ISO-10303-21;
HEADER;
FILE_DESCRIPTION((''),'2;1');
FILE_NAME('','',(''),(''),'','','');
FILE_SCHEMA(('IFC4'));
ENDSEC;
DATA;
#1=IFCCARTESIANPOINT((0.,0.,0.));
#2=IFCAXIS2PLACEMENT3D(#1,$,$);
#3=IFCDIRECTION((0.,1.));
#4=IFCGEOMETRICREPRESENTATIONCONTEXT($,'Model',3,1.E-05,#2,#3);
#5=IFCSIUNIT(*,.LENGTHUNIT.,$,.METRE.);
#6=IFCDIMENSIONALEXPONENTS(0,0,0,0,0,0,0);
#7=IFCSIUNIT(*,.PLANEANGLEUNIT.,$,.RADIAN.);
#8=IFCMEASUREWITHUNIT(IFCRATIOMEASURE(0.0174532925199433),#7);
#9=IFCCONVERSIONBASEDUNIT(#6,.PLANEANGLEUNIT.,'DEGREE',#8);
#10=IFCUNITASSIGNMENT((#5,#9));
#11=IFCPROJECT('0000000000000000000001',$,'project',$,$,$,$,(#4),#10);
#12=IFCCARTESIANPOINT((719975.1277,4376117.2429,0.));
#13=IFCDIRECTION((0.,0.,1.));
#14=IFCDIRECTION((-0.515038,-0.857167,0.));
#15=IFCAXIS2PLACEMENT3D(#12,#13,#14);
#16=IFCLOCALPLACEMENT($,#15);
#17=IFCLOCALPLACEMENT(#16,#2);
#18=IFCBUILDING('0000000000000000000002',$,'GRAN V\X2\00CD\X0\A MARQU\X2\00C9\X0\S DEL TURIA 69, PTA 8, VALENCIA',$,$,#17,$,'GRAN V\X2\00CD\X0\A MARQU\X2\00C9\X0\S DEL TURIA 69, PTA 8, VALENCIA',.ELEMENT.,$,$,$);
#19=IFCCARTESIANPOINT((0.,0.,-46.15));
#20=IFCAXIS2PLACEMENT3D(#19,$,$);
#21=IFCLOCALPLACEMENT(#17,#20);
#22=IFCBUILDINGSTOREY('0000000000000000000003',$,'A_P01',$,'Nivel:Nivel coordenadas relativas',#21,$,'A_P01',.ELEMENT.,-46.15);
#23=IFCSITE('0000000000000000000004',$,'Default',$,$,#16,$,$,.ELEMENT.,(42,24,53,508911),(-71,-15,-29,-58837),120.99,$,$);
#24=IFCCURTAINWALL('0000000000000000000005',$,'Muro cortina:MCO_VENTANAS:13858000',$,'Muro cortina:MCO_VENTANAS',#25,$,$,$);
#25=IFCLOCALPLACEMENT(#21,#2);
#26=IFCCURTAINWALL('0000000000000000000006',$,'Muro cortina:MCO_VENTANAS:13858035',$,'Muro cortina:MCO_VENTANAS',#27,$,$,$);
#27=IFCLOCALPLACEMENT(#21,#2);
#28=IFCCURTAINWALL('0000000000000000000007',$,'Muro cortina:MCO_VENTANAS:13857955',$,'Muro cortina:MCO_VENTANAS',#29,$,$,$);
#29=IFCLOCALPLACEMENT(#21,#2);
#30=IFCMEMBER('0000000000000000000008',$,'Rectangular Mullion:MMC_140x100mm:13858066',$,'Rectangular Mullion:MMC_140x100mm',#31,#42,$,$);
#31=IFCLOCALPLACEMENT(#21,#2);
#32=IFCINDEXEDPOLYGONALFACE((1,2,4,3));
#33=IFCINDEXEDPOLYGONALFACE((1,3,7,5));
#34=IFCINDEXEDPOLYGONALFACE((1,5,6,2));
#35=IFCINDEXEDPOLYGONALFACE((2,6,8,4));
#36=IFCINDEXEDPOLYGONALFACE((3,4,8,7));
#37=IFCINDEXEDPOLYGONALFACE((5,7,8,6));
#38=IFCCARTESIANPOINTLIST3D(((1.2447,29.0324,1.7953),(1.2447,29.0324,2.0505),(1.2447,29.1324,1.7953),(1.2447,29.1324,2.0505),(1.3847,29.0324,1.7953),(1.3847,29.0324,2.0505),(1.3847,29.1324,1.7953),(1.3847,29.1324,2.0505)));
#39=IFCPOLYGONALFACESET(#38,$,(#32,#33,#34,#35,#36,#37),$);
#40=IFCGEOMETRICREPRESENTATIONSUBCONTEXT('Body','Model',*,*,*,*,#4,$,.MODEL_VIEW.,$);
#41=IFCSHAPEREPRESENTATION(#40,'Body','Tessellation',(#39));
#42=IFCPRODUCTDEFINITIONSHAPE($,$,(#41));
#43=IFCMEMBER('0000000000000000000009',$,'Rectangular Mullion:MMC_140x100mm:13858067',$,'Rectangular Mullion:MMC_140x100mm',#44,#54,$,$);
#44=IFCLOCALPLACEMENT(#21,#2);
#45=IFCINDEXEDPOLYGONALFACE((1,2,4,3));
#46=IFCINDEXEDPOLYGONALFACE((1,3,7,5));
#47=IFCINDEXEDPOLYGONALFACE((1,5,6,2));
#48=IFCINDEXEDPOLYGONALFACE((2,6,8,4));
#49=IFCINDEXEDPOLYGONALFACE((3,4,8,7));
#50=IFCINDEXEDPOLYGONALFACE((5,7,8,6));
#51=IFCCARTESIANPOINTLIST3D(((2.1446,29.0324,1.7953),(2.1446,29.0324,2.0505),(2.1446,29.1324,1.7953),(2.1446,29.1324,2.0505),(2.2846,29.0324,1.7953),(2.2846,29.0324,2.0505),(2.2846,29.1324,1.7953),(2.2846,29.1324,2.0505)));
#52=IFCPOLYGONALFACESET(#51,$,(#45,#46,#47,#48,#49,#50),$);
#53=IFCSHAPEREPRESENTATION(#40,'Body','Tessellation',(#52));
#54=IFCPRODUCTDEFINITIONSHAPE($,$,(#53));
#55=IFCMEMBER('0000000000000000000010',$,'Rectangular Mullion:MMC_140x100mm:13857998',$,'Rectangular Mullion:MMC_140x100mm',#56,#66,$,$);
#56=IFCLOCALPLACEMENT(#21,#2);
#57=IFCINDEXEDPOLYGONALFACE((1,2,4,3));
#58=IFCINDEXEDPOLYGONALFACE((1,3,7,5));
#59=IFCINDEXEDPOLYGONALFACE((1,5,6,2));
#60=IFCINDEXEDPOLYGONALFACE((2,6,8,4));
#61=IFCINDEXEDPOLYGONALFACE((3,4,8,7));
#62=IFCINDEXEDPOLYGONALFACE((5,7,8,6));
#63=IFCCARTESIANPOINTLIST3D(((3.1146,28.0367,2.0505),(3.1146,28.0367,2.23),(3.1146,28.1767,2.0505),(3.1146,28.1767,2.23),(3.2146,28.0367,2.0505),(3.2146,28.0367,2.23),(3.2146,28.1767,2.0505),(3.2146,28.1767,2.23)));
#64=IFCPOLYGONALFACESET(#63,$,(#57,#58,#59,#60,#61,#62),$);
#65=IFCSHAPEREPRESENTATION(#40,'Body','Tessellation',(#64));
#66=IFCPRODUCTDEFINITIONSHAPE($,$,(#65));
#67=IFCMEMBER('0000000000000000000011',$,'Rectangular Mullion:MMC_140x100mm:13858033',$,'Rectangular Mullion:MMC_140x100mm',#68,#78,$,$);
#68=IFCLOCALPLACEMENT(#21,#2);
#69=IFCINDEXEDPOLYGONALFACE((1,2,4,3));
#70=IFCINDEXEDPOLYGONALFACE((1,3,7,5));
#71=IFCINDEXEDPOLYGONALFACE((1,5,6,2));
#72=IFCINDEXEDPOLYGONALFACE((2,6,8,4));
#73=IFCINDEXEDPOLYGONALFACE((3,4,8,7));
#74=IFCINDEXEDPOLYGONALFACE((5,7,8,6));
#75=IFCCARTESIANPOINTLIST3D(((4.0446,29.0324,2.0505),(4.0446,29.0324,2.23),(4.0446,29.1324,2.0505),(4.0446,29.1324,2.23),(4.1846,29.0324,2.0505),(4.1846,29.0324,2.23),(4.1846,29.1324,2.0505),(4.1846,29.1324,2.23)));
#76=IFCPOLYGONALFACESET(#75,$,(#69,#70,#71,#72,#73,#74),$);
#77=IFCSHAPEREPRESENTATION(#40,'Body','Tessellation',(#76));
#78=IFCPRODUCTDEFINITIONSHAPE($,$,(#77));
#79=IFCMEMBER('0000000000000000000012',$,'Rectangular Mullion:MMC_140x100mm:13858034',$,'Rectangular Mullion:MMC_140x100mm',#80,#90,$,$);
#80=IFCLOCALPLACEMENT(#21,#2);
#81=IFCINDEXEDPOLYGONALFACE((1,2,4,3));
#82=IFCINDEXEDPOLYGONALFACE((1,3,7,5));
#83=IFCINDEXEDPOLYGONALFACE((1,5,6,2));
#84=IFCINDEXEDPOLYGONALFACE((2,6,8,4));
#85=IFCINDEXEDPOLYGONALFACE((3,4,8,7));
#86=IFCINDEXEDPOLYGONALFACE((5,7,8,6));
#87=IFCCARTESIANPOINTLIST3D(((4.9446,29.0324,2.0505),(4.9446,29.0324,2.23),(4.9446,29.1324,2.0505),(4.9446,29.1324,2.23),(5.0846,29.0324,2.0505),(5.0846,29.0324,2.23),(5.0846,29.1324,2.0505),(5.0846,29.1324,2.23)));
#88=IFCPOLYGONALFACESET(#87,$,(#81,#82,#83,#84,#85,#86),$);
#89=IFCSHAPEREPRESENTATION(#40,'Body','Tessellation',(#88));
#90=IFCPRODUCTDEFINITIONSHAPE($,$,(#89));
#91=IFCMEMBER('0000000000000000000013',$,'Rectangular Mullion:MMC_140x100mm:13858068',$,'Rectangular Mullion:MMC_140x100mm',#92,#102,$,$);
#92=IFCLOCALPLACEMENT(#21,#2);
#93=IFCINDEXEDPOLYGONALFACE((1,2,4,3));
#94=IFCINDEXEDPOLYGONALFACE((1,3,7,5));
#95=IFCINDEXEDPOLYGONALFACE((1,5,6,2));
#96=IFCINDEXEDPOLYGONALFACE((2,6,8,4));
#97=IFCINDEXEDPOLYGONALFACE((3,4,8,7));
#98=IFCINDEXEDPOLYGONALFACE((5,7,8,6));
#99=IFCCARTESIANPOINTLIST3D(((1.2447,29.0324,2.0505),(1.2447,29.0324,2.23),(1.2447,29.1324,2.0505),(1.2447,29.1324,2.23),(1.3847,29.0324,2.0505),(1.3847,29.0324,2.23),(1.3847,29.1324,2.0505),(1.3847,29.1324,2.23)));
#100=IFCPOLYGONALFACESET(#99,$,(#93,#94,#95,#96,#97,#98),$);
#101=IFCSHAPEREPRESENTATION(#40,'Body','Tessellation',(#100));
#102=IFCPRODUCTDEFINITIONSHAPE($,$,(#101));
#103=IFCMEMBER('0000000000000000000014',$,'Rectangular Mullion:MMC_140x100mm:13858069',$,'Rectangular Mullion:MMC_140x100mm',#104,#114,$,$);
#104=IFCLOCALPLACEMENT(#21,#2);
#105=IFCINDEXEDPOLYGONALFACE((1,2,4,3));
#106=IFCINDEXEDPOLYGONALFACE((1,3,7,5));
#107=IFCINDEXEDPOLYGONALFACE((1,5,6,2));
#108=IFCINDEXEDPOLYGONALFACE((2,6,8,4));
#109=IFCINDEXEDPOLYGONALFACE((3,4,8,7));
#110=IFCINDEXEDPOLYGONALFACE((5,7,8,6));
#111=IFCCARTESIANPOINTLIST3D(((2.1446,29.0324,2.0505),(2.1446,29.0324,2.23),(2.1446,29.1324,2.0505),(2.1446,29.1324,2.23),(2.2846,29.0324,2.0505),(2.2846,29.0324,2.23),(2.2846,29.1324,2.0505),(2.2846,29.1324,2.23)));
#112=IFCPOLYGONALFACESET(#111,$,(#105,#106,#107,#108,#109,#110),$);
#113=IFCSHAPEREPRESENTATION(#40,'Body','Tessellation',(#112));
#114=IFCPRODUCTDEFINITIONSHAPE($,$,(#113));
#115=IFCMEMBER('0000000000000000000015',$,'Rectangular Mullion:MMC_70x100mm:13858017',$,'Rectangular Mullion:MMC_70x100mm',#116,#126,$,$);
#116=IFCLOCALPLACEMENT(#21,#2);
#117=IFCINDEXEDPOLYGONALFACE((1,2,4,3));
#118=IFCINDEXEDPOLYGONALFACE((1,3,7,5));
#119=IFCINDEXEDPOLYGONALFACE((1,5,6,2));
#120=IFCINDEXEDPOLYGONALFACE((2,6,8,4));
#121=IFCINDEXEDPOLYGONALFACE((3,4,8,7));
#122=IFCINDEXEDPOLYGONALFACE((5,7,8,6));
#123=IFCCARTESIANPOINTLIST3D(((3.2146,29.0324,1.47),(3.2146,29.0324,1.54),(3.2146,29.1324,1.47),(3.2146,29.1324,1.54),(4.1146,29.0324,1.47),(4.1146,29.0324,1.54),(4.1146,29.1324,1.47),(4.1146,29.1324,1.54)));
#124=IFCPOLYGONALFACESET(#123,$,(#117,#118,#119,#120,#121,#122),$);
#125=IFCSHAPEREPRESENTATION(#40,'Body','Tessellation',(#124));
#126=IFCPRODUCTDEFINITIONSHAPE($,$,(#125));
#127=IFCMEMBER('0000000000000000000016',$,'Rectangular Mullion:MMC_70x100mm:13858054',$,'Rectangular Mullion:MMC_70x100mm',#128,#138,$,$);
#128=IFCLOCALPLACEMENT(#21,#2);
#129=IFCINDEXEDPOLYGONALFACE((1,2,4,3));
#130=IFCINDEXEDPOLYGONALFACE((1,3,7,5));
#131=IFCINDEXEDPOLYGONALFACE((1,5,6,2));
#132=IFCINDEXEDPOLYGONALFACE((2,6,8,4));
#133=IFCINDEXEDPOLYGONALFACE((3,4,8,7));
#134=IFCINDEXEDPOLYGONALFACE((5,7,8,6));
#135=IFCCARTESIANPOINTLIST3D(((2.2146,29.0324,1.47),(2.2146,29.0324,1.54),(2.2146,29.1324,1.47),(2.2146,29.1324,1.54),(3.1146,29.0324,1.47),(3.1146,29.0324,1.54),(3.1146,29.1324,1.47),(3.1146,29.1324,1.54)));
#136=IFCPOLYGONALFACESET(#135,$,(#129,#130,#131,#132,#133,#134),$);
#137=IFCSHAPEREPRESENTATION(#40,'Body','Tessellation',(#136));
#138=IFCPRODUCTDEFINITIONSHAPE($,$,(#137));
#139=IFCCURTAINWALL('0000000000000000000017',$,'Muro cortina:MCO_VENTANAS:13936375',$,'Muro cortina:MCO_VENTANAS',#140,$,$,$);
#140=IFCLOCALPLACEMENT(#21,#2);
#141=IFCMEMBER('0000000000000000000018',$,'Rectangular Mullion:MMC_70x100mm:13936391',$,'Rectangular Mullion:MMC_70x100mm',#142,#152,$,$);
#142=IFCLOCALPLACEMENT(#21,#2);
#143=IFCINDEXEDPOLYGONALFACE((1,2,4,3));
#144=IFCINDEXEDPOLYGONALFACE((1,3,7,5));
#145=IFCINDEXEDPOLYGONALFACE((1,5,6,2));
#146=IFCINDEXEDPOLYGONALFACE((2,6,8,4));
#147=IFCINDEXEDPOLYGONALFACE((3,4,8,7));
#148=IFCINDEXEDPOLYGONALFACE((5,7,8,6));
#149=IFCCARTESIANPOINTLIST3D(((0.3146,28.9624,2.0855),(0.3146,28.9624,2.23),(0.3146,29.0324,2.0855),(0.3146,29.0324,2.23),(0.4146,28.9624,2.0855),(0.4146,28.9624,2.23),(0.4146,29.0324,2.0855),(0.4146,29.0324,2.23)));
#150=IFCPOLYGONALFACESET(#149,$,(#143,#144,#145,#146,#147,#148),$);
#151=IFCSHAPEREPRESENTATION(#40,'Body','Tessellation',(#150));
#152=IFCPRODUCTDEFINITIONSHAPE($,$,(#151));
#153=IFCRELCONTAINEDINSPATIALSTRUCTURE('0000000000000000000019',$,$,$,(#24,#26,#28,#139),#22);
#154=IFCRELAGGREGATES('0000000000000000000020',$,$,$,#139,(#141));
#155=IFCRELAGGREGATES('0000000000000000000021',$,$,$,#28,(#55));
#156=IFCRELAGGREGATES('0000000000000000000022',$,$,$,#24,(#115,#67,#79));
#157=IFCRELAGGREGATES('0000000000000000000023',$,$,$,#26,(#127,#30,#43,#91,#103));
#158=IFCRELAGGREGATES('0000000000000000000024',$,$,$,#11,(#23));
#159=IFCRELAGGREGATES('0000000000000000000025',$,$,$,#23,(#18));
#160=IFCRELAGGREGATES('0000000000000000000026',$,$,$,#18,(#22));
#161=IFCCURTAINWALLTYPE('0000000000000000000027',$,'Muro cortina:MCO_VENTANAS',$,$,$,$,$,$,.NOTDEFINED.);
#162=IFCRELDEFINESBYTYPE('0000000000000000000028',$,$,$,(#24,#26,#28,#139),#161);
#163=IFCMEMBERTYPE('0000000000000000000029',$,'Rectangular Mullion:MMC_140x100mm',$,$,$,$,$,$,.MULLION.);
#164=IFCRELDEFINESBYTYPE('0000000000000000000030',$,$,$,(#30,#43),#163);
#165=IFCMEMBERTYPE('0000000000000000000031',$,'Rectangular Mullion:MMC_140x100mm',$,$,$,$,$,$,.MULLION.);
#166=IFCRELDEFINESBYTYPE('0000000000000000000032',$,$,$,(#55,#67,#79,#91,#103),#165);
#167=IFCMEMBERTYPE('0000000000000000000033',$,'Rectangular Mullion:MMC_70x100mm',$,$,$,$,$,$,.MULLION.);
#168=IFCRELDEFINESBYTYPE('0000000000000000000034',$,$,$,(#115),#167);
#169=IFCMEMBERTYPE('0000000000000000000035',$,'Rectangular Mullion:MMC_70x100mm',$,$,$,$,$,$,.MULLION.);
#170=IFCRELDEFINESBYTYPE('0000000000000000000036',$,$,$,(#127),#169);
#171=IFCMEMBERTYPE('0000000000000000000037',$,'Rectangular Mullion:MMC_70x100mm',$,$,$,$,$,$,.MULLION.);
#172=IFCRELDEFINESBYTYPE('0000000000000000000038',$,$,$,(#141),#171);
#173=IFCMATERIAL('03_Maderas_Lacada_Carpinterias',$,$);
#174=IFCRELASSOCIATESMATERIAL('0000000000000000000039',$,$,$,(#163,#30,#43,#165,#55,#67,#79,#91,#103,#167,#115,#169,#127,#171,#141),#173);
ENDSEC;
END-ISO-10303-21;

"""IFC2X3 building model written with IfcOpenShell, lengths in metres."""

from ifc_helpers import new_model, entity, si_unit, converted_unit, direction, frame, origin, origin_2d_with_axis, place, context, subcontext, project, spatial, rectangle, extrude, source, transform, mapped, material, type_object, type_shapes, element, aggregate, save


model = new_model("IFC2X3")

# Units and contexts
model_context = context("Model", 3, precision=1e-05, world=origin(), true_north=direction((0.0, 1.0)))
body_context = subcontext(model_context, "Body", "Model", "MODEL_VIEW")
ifc_project = project(units=[si_unit("LENGTHUNIT", "METRE"), converted_unit("PLANEANGLEUNIT", "DEGREE", entity("IfcRatioMeasure", 0.0174532925199433), si_unit("PLANEANGLEUNIT", "RADIAN"), dimensions=[0, 0, 0, 0, 0, 0, 0])], contexts=[model_context])

# Site, building, storey
site_placement = place(None, frame((719975.1277, 4376117.2429, 0.0), z_axis=(0.0, 0.0, 1.0), x_axis=(-0.515038, -0.857167, 0.0)))
site = spatial("IfcSite", under=ifc_project, at=site_placement, Name="Default", CompositionType="ELEMENT", RefLatitude=(42, 24, 53, 508911), RefLongitude=(-71, -15, -29, -58837), RefElevation=120.99)
building_placement = place(site_placement, origin())
building = spatial("IfcBuilding", under=site, at=building_placement, Name="GRAN VÍA MARQUÉS DEL TURIA 69, PTA 8, VALENCIA", LongName="GRAN VÍA MARQUÉS DEL TURIA 69, PTA 8, VALENCIA", CompositionType="ELEMENT")
storey_placement = place(building_placement, frame((0.0, 0.0, -46.15)))
storey = spatial("IfcBuildingStorey", under=building, at=storey_placement, Name="A_P01", ObjectType="Nivel:Nivel coordenadas relativas", LongName="A_P01", CompositionType="ELEMENT", Elevation=-46.15)

# Curtain wall
curtain_wall_type = type_object("IfcCurtainWallType", Name="Muro cortina:MCO_VENTANAS", PredefinedType="NOTDEFINED")
curtain_wall_1_placement = place(storey_placement, frame((0.0, 0.0, 46.15)))
curtain_wall_1 = element("IfcCurtainWall", 1, at=curtain_wall_1_placement, inside=storey, type_object=curtain_wall_type, Name="Muro cortina:MCO_VENTANAS:13858000", ObjectType="Muro cortina:MCO_VENTANAS")
ifc_material_1 = material(Name="03_Maderas_Lacada_Carpinterias")

# Curtain wall
curtain_wall_2_placement = place(storey_placement, frame((0.0, 0.0, 46.15)))
curtain_wall_2 = element("IfcCurtainWall", 2, at=curtain_wall_2_placement, inside=storey, type_object=curtain_wall_type, Name="Muro cortina:MCO_VENTANAS:13858035", ObjectType="Muro cortina:MCO_VENTANAS")

# Curtain wall
curtain_wall_3_placement = place(storey_placement, frame((0.0, 0.0, 46.15)))
curtain_wall_3 = element("IfcCurtainWall", 3, at=curtain_wall_3_placement, inside=storey, type_object=curtain_wall_type, Name="Muro cortina:MCO_VENTANAS:13857955", ObjectType="Muro cortina:MCO_VENTANAS")

# Members
member_type_1 = type_object("IfcMemberType", Name="Rectangular Mullion:MMC_140x100mm", PredefinedType="MULLION", material=ifc_material_1)
shared_shape_1 = source(origin(), body_context, "Body", "SweptSolid", [
    extrude(rectangle(XDim=0.1, YDim=0.14, at=origin_2d_with_axis()), frame((0.0, 0.0, -0.2552), z_axis=(0.0, 0.0, 1.0), x_axis=(0.0, -1.0, 0.0)), (0.0, 0.0, 1.0), 0.2552),
])
type_shapes(member_type_1, [shared_shape_1])
member_1_placement = place(storey_placement, frame((1.3147, 29.0824, 1.7953), z_axis=(0.0, 0.0, -1.0), x_axis=(1.0, 0.0, 0.0)))
member_1 = element("IfcMember", 4, at=member_1_placement, type_object=member_type_1, material=ifc_material_1, Name="Rectangular Mullion:MMC_140x100mm:13858066", ObjectType="Rectangular Mullion:MMC_140x100mm", context=body_context, shape_type="MappedRepresentation", body=[
    mapped(shared_shape_1, transform((0.0, 0.0, 0.0), scale=1.0)),
])
member_2_placement = place(storey_placement, frame((2.2146, 29.0824, 1.7953), z_axis=(0.0, 0.0, -1.0), x_axis=(1.0, 0.0, 0.0)))
member_2 = element("IfcMember", 5, at=member_2_placement, type_object=member_type_1, material=ifc_material_1, Name="Rectangular Mullion:MMC_140x100mm:13858067", ObjectType="Rectangular Mullion:MMC_140x100mm", context=body_context, shape_type="MappedRepresentation", body=[
    mapped(shared_shape_1, transform((0.0, 0.0, 0.0), scale=1.0)),
])
member_type_2 = type_object("IfcMemberType", Name="Rectangular Mullion:MMC_140x100mm", PredefinedType="MULLION", material=ifc_material_1)
shared_shape_2 = source(origin(), body_context, "Body", "SweptSolid", [
    extrude(rectangle(XDim=0.1, YDim=0.14, at=origin_2d_with_axis()), frame((0.0, 0.0, -0.1795), z_axis=(0.0, 0.0, 1.0), x_axis=(0.0, -1.0, 0.0)), (0.0, 0.0, 1.0), 0.1795),
])
type_shapes(member_type_2, [shared_shape_2])
member_3_placement = place(storey_placement, frame((3.1646, 28.1067, 2.0505), z_axis=(0.0, 0.0, -1.0), x_axis=(0.0, 1.0, 0.0)))
member_3 = element("IfcMember", 6, at=member_3_placement, type_object=member_type_2, material=ifc_material_1, Name="Rectangular Mullion:MMC_140x100mm:13857998", ObjectType="Rectangular Mullion:MMC_140x100mm", context=body_context, shape_type="MappedRepresentation", body=[
    mapped(shared_shape_2, transform((0.0, 0.0, 0.0), scale=1.0)),
])
member_4_placement = place(storey_placement, frame((4.1146, 29.0824, 2.0505), z_axis=(0.0, 0.0, -1.0), x_axis=(1.0, 0.0, 0.0)))
member_4 = element("IfcMember", 7, at=member_4_placement, type_object=member_type_2, material=ifc_material_1, Name="Rectangular Mullion:MMC_140x100mm:13858033", ObjectType="Rectangular Mullion:MMC_140x100mm", context=body_context, shape_type="MappedRepresentation", body=[
    mapped(shared_shape_2, transform((0.0, 0.0, 0.0), scale=1.0)),
])
member_5_placement = place(storey_placement, frame((5.0146, 29.0824, 2.0505), z_axis=(0.0, 0.0, -1.0), x_axis=(1.0, 0.0, 0.0)))
member_5 = element("IfcMember", 8, at=member_5_placement, type_object=member_type_2, material=ifc_material_1, Name="Rectangular Mullion:MMC_140x100mm:13858034", ObjectType="Rectangular Mullion:MMC_140x100mm", context=body_context, shape_type="MappedRepresentation", body=[
    mapped(shared_shape_2, transform((0.0, 0.0, 0.0), scale=1.0)),
])
member_6_placement = place(storey_placement, frame((1.3147, 29.0824, 2.0505), z_axis=(0.0, 0.0, -1.0), x_axis=(1.0, 0.0, 0.0)))
member_6 = element("IfcMember", 9, at=member_6_placement, type_object=member_type_2, material=ifc_material_1, Name="Rectangular Mullion:MMC_140x100mm:13858068", ObjectType="Rectangular Mullion:MMC_140x100mm", context=body_context, shape_type="MappedRepresentation", body=[
    mapped(shared_shape_2, transform((0.0, 0.0, 0.0), scale=1.0)),
])
member_7_placement = place(storey_placement, frame((2.2146, 29.0824, 2.0505), z_axis=(0.0, 0.0, -1.0), x_axis=(1.0, 0.0, 0.0)))
member_7 = element("IfcMember", 10, at=member_7_placement, type_object=member_type_2, material=ifc_material_1, Name="Rectangular Mullion:MMC_140x100mm:13858069", ObjectType="Rectangular Mullion:MMC_140x100mm", context=body_context, shape_type="MappedRepresentation", body=[
    mapped(shared_shape_2, transform((0.0, 0.0, 0.0), scale=1.0)),
])
member_type_3 = type_object("IfcMemberType", Name="Rectangular Mullion:MMC_70x100mm", PredefinedType="MULLION", material=ifc_material_1)
shared_shape_3 = source(origin(), body_context, "Body", "SweptSolid", [
    extrude(rectangle(XDim=0.1, YDim=0.07, at=origin_2d_with_axis()), frame((-0.035, 0.0, -0.9), z_axis=(0.0, 0.0, 1.0), x_axis=(0.0, -1.0, 0.0)), (0.0, 0.0, 1.0), 0.9),
])
type_shapes(member_type_3, [shared_shape_3])
member_8_placement = place(storey_placement, frame((3.2146, 29.0824, 1.47), z_axis=(-1.0, 0.0, 0.0), x_axis=(0.0, 0.0, -1.0)))
member_8 = element("IfcMember", 11, at=member_8_placement, type_object=member_type_3, material=ifc_material_1, Name="Rectangular Mullion:MMC_70x100mm:13858017", ObjectType="Rectangular Mullion:MMC_70x100mm", context=body_context, shape_type="MappedRepresentation", body=[
    mapped(shared_shape_3, transform((0.0, 0.0, 0.0), scale=1.0)),
])
member_type_4 = type_object("IfcMemberType", Name="Rectangular Mullion:MMC_70x100mm", PredefinedType="MULLION", material=ifc_material_1)
shared_shape_4 = source(origin(), body_context, "Body", "SweptSolid", [
    extrude(rectangle(XDim=0.1, YDim=0.07, at=origin_2d_with_axis()), frame((-0.035, 0.0, -0.9), z_axis=(0.0, 0.0, 1.0), x_axis=(0.0, -1.0, 0.0)), (0.0, 0.0, 1.0), 0.9),
])
type_shapes(member_type_4, [shared_shape_4])
member_9_placement = place(storey_placement, frame((2.2146, 29.0824, 1.47), z_axis=(-1.0, 0.0, 0.0), x_axis=(0.0, 0.0, -1.0)))
member_9 = element("IfcMember", 12, at=member_9_placement, type_object=member_type_4, material=ifc_material_1, Name="Rectangular Mullion:MMC_70x100mm:13858054", ObjectType="Rectangular Mullion:MMC_70x100mm", context=body_context, shape_type="MappedRepresentation", body=[
    mapped(shared_shape_4, transform((0.0, 0.0, 0.0), scale=1.0)),
])

# Curtain wall, member
curtain_wall_4_placement = place(storey_placement, frame((0.0, 0.0, 46.15)))
curtain_wall_4 = element("IfcCurtainWall", 13, at=curtain_wall_4_placement, inside=storey, type_object=curtain_wall_type, Name="Muro cortina:MCO_VENTANAS:13936375", ObjectType="Muro cortina:MCO_VENTANAS")
member_type_5 = type_object("IfcMemberType", Name="Rectangular Mullion:MMC_70x100mm", PredefinedType="MULLION", material=ifc_material_1)
shared_shape_5 = source(origin(), body_context, "Body", "SweptSolid", [
    extrude(rectangle(XDim=0.1, YDim=0.07, at=origin_2d_with_axis()), frame((-0.035, 0.0, -0.1445), z_axis=(0.0, 0.0, 1.0), x_axis=(0.0, -1.0, 0.0)), (0.0, 0.0, 1.0), 0.1445),
])
type_shapes(member_type_5, [shared_shape_5])
member_10_placement = place(storey_placement, frame((0.3646, 29.0324, 2.0855), z_axis=(0.0, 0.0, -1.0), x_axis=(0.0, 1.0, 0.0)))
member_10 = element("IfcMember", 14, at=member_10_placement, type_object=member_type_5, material=ifc_material_1, Name="Rectangular Mullion:MMC_70x100mm:13936391", ObjectType="Rectangular Mullion:MMC_70x100mm", context=body_context, shape_type="MappedRepresentation", body=[
    mapped(shared_shape_5, transform((0.0, 0.0, 0.0), scale=1.0)),
])
aggregate(curtain_wall_4, [member_10])

aggregate(curtain_wall_3, [member_3])
aggregate(curtain_wall_1, [member_8, member_4, member_5])
aggregate(curtain_wall_2, [member_9, member_1, member_2, member_6, member_7])

save(model, "model.ifc")
